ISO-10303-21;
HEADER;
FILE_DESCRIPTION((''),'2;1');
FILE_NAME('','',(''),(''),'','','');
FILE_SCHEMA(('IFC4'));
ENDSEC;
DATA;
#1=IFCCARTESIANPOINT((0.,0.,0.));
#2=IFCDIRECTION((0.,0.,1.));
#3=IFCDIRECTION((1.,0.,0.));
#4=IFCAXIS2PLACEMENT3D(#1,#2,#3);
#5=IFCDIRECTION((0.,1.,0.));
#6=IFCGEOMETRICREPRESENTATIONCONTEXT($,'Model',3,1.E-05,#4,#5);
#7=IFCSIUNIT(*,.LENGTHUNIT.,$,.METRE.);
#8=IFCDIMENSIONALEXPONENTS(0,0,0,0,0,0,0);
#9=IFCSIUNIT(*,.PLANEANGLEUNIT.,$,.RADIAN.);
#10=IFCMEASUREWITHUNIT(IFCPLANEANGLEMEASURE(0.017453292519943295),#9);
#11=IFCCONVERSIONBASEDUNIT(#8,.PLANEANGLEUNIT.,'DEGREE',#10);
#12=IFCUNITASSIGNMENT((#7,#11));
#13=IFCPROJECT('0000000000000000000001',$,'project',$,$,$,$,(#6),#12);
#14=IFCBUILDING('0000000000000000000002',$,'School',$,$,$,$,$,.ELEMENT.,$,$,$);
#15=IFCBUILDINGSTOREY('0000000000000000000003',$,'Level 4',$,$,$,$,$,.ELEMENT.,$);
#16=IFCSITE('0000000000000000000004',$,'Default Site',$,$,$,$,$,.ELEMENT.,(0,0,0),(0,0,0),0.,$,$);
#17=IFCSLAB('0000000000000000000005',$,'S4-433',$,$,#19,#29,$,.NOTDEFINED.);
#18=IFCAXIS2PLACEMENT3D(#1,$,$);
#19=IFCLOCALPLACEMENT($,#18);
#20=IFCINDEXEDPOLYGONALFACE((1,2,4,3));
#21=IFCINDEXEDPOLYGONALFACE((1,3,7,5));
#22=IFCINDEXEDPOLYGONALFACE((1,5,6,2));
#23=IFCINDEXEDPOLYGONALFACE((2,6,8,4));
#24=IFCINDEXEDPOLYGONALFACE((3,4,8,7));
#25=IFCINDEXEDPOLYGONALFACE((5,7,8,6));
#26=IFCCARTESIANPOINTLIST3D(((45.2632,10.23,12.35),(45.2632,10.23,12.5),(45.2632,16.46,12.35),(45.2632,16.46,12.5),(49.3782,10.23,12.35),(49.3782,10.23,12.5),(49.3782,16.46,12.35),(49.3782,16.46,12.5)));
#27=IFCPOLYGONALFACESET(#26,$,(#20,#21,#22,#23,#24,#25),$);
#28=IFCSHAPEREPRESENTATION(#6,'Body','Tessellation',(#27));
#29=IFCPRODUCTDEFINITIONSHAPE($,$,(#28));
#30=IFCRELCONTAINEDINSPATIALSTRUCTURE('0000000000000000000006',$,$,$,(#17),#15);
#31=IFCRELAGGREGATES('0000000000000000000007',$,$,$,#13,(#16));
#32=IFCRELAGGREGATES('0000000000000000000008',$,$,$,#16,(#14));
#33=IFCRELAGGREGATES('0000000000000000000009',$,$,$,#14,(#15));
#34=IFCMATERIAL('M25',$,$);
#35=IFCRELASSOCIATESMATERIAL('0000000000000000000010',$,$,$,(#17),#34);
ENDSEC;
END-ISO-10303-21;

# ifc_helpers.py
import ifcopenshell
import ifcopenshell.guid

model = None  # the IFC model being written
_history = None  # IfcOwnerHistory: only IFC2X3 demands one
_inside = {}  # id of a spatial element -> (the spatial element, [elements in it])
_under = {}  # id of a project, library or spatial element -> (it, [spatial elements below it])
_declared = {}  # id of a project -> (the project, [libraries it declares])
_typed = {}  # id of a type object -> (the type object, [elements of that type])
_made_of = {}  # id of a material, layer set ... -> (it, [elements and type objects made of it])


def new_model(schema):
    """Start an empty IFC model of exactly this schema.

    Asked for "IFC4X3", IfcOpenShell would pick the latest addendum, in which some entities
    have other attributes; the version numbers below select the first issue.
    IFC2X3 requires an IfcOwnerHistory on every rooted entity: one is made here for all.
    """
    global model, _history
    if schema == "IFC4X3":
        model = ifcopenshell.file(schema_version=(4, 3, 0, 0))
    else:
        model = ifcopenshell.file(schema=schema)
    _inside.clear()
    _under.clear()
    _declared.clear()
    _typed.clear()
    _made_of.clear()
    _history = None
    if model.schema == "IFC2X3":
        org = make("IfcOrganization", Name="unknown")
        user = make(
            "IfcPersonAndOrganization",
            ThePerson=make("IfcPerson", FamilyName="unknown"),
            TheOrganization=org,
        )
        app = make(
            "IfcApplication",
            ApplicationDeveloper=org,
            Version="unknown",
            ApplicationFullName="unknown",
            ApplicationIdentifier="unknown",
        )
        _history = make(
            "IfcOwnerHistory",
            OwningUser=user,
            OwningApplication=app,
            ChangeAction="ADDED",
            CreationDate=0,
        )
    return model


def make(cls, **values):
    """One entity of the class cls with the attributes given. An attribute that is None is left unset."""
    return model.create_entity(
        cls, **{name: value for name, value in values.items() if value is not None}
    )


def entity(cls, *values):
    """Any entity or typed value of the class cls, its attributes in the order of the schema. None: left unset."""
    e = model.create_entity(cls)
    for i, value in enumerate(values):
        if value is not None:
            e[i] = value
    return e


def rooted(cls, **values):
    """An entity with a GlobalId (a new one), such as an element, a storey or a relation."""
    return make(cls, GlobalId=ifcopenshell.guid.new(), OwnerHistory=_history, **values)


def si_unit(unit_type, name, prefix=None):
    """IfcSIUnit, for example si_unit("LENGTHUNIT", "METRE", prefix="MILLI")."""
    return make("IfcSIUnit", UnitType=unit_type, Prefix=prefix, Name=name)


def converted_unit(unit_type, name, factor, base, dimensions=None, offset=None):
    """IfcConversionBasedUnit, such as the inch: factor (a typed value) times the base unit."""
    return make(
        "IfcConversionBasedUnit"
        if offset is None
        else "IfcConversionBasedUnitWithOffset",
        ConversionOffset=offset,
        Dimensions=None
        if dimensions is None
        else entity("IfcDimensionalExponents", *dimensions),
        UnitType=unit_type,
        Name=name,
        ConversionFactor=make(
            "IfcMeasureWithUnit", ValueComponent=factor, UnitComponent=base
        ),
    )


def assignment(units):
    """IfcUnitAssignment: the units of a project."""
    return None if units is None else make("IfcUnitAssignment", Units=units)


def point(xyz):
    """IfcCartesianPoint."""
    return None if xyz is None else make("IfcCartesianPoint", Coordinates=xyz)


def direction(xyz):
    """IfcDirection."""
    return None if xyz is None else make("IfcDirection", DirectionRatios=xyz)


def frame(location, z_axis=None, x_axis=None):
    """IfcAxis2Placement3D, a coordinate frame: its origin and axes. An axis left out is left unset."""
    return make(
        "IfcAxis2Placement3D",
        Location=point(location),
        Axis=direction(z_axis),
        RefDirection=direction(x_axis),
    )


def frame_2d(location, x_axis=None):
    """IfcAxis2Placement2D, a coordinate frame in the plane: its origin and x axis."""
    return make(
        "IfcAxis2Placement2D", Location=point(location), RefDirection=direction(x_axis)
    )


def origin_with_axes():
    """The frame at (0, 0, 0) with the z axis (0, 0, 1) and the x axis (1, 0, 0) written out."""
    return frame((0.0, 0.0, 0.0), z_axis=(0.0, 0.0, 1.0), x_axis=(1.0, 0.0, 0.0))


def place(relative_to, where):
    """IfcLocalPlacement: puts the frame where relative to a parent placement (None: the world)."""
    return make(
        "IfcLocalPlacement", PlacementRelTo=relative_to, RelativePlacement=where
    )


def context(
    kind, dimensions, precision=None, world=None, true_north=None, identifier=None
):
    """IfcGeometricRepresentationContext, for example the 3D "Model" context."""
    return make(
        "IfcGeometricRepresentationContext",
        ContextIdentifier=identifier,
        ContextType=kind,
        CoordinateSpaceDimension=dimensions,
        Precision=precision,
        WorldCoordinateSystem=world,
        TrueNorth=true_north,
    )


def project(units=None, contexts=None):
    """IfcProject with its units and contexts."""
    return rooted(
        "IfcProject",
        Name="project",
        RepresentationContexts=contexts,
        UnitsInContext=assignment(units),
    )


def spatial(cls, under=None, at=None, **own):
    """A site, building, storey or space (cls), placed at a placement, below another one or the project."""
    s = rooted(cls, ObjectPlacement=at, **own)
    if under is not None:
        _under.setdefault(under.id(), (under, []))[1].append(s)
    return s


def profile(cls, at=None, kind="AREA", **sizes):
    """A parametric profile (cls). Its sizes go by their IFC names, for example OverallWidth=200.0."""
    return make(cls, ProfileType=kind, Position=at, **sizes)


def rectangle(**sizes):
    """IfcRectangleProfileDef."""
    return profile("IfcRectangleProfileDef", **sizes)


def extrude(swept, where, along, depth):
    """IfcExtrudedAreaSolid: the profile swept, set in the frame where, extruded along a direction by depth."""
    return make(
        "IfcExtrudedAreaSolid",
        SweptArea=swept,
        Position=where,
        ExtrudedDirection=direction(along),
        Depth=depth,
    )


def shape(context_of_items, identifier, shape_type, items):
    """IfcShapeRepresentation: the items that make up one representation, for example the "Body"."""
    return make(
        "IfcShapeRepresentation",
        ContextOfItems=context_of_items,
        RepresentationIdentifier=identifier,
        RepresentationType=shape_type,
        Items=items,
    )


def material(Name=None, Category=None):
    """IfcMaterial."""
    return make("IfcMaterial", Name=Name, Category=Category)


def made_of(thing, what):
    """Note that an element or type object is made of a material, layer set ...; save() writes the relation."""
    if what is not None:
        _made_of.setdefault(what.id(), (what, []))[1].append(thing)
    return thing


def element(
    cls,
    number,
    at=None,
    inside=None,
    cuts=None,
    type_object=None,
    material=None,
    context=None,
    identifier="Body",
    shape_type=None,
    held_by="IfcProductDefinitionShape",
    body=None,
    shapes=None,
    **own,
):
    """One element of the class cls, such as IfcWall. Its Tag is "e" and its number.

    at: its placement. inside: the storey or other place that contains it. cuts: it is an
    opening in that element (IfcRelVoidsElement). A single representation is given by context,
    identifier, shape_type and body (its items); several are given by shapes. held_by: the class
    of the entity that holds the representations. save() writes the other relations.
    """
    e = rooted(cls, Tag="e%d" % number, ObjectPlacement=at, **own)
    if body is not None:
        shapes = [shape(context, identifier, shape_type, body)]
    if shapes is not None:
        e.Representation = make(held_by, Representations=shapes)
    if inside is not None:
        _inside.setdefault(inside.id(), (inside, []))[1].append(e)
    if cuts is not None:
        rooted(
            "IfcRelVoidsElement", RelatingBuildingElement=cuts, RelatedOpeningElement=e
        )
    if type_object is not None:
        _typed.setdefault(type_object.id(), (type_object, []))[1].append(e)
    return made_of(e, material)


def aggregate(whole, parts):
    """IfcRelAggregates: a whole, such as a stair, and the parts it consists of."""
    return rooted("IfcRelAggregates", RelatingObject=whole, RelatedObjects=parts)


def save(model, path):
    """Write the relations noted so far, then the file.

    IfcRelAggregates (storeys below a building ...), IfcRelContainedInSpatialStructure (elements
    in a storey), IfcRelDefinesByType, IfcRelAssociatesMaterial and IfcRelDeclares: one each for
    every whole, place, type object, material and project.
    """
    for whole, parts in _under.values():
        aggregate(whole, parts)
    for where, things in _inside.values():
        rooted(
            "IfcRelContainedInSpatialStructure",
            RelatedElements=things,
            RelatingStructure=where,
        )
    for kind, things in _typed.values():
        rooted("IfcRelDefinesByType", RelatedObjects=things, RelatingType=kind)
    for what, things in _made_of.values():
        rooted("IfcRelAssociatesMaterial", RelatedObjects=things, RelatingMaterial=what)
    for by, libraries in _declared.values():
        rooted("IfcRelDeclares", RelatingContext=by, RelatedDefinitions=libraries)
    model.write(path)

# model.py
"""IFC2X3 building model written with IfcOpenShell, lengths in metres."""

from ifc_helpers import new_model, entity, si_unit, converted_unit, direction, frame, frame_2d, origin_with_axes, place, context, project, spatial, rectangle, extrude, material, element, save


model = new_model("IFC2X3")

# Units and contexts
model_context = context("Model", 3, precision=1e-05, world=origin_with_axes(), true_north=direction((0.0, 1.0, 0.0)))
ifc_project = project(units=[si_unit("LENGTHUNIT", "METRE"), converted_unit("PLANEANGLEUNIT", "DEGREE", entity("IfcPlaneAngleMeasure", 0.017453292519943295), si_unit("PLANEANGLEUNIT", "RADIAN"), dimensions=[0, 0, 0, 0, 0, 0, 0])], contexts=[model_context])

# Site, building, storey
site = spatial("IfcSite", under=ifc_project, Name="Default Site", CompositionType="ELEMENT", RefLatitude=(0, 0, 0), RefLongitude=(0, 0, 0), RefElevation=0.0)
building = spatial("IfcBuilding", under=site, Name="School", CompositionType="ELEMENT")
storey = spatial("IfcBuildingStorey", under=building, Name="Level 4", CompositionType="ELEMENT")

# Slab
ifc_material = material(Name="M25")
placement = place(None, origin_with_axes())
element("IfcSlab", 1, at=placement, inside=storey, material=ifc_material, Name="S4-433", PredefinedType="NOTDEFINED", context=model_context, shape_type="SweptSolid", body=[
    extrude(rectangle(XDim=4.115, YDim=6.23, at=frame_2d((0.0, 0.0), x_axis=(1.0, 0.0, 0.0))), frame((47.3207, 13.345, 12.35), z_axis=(0.0, 0.0, 1.0), x_axis=(1.0, 0.0, 0.0)), (0.0, 0.0, 1.0), 0.15),
])

save(model, "model.ifc")
